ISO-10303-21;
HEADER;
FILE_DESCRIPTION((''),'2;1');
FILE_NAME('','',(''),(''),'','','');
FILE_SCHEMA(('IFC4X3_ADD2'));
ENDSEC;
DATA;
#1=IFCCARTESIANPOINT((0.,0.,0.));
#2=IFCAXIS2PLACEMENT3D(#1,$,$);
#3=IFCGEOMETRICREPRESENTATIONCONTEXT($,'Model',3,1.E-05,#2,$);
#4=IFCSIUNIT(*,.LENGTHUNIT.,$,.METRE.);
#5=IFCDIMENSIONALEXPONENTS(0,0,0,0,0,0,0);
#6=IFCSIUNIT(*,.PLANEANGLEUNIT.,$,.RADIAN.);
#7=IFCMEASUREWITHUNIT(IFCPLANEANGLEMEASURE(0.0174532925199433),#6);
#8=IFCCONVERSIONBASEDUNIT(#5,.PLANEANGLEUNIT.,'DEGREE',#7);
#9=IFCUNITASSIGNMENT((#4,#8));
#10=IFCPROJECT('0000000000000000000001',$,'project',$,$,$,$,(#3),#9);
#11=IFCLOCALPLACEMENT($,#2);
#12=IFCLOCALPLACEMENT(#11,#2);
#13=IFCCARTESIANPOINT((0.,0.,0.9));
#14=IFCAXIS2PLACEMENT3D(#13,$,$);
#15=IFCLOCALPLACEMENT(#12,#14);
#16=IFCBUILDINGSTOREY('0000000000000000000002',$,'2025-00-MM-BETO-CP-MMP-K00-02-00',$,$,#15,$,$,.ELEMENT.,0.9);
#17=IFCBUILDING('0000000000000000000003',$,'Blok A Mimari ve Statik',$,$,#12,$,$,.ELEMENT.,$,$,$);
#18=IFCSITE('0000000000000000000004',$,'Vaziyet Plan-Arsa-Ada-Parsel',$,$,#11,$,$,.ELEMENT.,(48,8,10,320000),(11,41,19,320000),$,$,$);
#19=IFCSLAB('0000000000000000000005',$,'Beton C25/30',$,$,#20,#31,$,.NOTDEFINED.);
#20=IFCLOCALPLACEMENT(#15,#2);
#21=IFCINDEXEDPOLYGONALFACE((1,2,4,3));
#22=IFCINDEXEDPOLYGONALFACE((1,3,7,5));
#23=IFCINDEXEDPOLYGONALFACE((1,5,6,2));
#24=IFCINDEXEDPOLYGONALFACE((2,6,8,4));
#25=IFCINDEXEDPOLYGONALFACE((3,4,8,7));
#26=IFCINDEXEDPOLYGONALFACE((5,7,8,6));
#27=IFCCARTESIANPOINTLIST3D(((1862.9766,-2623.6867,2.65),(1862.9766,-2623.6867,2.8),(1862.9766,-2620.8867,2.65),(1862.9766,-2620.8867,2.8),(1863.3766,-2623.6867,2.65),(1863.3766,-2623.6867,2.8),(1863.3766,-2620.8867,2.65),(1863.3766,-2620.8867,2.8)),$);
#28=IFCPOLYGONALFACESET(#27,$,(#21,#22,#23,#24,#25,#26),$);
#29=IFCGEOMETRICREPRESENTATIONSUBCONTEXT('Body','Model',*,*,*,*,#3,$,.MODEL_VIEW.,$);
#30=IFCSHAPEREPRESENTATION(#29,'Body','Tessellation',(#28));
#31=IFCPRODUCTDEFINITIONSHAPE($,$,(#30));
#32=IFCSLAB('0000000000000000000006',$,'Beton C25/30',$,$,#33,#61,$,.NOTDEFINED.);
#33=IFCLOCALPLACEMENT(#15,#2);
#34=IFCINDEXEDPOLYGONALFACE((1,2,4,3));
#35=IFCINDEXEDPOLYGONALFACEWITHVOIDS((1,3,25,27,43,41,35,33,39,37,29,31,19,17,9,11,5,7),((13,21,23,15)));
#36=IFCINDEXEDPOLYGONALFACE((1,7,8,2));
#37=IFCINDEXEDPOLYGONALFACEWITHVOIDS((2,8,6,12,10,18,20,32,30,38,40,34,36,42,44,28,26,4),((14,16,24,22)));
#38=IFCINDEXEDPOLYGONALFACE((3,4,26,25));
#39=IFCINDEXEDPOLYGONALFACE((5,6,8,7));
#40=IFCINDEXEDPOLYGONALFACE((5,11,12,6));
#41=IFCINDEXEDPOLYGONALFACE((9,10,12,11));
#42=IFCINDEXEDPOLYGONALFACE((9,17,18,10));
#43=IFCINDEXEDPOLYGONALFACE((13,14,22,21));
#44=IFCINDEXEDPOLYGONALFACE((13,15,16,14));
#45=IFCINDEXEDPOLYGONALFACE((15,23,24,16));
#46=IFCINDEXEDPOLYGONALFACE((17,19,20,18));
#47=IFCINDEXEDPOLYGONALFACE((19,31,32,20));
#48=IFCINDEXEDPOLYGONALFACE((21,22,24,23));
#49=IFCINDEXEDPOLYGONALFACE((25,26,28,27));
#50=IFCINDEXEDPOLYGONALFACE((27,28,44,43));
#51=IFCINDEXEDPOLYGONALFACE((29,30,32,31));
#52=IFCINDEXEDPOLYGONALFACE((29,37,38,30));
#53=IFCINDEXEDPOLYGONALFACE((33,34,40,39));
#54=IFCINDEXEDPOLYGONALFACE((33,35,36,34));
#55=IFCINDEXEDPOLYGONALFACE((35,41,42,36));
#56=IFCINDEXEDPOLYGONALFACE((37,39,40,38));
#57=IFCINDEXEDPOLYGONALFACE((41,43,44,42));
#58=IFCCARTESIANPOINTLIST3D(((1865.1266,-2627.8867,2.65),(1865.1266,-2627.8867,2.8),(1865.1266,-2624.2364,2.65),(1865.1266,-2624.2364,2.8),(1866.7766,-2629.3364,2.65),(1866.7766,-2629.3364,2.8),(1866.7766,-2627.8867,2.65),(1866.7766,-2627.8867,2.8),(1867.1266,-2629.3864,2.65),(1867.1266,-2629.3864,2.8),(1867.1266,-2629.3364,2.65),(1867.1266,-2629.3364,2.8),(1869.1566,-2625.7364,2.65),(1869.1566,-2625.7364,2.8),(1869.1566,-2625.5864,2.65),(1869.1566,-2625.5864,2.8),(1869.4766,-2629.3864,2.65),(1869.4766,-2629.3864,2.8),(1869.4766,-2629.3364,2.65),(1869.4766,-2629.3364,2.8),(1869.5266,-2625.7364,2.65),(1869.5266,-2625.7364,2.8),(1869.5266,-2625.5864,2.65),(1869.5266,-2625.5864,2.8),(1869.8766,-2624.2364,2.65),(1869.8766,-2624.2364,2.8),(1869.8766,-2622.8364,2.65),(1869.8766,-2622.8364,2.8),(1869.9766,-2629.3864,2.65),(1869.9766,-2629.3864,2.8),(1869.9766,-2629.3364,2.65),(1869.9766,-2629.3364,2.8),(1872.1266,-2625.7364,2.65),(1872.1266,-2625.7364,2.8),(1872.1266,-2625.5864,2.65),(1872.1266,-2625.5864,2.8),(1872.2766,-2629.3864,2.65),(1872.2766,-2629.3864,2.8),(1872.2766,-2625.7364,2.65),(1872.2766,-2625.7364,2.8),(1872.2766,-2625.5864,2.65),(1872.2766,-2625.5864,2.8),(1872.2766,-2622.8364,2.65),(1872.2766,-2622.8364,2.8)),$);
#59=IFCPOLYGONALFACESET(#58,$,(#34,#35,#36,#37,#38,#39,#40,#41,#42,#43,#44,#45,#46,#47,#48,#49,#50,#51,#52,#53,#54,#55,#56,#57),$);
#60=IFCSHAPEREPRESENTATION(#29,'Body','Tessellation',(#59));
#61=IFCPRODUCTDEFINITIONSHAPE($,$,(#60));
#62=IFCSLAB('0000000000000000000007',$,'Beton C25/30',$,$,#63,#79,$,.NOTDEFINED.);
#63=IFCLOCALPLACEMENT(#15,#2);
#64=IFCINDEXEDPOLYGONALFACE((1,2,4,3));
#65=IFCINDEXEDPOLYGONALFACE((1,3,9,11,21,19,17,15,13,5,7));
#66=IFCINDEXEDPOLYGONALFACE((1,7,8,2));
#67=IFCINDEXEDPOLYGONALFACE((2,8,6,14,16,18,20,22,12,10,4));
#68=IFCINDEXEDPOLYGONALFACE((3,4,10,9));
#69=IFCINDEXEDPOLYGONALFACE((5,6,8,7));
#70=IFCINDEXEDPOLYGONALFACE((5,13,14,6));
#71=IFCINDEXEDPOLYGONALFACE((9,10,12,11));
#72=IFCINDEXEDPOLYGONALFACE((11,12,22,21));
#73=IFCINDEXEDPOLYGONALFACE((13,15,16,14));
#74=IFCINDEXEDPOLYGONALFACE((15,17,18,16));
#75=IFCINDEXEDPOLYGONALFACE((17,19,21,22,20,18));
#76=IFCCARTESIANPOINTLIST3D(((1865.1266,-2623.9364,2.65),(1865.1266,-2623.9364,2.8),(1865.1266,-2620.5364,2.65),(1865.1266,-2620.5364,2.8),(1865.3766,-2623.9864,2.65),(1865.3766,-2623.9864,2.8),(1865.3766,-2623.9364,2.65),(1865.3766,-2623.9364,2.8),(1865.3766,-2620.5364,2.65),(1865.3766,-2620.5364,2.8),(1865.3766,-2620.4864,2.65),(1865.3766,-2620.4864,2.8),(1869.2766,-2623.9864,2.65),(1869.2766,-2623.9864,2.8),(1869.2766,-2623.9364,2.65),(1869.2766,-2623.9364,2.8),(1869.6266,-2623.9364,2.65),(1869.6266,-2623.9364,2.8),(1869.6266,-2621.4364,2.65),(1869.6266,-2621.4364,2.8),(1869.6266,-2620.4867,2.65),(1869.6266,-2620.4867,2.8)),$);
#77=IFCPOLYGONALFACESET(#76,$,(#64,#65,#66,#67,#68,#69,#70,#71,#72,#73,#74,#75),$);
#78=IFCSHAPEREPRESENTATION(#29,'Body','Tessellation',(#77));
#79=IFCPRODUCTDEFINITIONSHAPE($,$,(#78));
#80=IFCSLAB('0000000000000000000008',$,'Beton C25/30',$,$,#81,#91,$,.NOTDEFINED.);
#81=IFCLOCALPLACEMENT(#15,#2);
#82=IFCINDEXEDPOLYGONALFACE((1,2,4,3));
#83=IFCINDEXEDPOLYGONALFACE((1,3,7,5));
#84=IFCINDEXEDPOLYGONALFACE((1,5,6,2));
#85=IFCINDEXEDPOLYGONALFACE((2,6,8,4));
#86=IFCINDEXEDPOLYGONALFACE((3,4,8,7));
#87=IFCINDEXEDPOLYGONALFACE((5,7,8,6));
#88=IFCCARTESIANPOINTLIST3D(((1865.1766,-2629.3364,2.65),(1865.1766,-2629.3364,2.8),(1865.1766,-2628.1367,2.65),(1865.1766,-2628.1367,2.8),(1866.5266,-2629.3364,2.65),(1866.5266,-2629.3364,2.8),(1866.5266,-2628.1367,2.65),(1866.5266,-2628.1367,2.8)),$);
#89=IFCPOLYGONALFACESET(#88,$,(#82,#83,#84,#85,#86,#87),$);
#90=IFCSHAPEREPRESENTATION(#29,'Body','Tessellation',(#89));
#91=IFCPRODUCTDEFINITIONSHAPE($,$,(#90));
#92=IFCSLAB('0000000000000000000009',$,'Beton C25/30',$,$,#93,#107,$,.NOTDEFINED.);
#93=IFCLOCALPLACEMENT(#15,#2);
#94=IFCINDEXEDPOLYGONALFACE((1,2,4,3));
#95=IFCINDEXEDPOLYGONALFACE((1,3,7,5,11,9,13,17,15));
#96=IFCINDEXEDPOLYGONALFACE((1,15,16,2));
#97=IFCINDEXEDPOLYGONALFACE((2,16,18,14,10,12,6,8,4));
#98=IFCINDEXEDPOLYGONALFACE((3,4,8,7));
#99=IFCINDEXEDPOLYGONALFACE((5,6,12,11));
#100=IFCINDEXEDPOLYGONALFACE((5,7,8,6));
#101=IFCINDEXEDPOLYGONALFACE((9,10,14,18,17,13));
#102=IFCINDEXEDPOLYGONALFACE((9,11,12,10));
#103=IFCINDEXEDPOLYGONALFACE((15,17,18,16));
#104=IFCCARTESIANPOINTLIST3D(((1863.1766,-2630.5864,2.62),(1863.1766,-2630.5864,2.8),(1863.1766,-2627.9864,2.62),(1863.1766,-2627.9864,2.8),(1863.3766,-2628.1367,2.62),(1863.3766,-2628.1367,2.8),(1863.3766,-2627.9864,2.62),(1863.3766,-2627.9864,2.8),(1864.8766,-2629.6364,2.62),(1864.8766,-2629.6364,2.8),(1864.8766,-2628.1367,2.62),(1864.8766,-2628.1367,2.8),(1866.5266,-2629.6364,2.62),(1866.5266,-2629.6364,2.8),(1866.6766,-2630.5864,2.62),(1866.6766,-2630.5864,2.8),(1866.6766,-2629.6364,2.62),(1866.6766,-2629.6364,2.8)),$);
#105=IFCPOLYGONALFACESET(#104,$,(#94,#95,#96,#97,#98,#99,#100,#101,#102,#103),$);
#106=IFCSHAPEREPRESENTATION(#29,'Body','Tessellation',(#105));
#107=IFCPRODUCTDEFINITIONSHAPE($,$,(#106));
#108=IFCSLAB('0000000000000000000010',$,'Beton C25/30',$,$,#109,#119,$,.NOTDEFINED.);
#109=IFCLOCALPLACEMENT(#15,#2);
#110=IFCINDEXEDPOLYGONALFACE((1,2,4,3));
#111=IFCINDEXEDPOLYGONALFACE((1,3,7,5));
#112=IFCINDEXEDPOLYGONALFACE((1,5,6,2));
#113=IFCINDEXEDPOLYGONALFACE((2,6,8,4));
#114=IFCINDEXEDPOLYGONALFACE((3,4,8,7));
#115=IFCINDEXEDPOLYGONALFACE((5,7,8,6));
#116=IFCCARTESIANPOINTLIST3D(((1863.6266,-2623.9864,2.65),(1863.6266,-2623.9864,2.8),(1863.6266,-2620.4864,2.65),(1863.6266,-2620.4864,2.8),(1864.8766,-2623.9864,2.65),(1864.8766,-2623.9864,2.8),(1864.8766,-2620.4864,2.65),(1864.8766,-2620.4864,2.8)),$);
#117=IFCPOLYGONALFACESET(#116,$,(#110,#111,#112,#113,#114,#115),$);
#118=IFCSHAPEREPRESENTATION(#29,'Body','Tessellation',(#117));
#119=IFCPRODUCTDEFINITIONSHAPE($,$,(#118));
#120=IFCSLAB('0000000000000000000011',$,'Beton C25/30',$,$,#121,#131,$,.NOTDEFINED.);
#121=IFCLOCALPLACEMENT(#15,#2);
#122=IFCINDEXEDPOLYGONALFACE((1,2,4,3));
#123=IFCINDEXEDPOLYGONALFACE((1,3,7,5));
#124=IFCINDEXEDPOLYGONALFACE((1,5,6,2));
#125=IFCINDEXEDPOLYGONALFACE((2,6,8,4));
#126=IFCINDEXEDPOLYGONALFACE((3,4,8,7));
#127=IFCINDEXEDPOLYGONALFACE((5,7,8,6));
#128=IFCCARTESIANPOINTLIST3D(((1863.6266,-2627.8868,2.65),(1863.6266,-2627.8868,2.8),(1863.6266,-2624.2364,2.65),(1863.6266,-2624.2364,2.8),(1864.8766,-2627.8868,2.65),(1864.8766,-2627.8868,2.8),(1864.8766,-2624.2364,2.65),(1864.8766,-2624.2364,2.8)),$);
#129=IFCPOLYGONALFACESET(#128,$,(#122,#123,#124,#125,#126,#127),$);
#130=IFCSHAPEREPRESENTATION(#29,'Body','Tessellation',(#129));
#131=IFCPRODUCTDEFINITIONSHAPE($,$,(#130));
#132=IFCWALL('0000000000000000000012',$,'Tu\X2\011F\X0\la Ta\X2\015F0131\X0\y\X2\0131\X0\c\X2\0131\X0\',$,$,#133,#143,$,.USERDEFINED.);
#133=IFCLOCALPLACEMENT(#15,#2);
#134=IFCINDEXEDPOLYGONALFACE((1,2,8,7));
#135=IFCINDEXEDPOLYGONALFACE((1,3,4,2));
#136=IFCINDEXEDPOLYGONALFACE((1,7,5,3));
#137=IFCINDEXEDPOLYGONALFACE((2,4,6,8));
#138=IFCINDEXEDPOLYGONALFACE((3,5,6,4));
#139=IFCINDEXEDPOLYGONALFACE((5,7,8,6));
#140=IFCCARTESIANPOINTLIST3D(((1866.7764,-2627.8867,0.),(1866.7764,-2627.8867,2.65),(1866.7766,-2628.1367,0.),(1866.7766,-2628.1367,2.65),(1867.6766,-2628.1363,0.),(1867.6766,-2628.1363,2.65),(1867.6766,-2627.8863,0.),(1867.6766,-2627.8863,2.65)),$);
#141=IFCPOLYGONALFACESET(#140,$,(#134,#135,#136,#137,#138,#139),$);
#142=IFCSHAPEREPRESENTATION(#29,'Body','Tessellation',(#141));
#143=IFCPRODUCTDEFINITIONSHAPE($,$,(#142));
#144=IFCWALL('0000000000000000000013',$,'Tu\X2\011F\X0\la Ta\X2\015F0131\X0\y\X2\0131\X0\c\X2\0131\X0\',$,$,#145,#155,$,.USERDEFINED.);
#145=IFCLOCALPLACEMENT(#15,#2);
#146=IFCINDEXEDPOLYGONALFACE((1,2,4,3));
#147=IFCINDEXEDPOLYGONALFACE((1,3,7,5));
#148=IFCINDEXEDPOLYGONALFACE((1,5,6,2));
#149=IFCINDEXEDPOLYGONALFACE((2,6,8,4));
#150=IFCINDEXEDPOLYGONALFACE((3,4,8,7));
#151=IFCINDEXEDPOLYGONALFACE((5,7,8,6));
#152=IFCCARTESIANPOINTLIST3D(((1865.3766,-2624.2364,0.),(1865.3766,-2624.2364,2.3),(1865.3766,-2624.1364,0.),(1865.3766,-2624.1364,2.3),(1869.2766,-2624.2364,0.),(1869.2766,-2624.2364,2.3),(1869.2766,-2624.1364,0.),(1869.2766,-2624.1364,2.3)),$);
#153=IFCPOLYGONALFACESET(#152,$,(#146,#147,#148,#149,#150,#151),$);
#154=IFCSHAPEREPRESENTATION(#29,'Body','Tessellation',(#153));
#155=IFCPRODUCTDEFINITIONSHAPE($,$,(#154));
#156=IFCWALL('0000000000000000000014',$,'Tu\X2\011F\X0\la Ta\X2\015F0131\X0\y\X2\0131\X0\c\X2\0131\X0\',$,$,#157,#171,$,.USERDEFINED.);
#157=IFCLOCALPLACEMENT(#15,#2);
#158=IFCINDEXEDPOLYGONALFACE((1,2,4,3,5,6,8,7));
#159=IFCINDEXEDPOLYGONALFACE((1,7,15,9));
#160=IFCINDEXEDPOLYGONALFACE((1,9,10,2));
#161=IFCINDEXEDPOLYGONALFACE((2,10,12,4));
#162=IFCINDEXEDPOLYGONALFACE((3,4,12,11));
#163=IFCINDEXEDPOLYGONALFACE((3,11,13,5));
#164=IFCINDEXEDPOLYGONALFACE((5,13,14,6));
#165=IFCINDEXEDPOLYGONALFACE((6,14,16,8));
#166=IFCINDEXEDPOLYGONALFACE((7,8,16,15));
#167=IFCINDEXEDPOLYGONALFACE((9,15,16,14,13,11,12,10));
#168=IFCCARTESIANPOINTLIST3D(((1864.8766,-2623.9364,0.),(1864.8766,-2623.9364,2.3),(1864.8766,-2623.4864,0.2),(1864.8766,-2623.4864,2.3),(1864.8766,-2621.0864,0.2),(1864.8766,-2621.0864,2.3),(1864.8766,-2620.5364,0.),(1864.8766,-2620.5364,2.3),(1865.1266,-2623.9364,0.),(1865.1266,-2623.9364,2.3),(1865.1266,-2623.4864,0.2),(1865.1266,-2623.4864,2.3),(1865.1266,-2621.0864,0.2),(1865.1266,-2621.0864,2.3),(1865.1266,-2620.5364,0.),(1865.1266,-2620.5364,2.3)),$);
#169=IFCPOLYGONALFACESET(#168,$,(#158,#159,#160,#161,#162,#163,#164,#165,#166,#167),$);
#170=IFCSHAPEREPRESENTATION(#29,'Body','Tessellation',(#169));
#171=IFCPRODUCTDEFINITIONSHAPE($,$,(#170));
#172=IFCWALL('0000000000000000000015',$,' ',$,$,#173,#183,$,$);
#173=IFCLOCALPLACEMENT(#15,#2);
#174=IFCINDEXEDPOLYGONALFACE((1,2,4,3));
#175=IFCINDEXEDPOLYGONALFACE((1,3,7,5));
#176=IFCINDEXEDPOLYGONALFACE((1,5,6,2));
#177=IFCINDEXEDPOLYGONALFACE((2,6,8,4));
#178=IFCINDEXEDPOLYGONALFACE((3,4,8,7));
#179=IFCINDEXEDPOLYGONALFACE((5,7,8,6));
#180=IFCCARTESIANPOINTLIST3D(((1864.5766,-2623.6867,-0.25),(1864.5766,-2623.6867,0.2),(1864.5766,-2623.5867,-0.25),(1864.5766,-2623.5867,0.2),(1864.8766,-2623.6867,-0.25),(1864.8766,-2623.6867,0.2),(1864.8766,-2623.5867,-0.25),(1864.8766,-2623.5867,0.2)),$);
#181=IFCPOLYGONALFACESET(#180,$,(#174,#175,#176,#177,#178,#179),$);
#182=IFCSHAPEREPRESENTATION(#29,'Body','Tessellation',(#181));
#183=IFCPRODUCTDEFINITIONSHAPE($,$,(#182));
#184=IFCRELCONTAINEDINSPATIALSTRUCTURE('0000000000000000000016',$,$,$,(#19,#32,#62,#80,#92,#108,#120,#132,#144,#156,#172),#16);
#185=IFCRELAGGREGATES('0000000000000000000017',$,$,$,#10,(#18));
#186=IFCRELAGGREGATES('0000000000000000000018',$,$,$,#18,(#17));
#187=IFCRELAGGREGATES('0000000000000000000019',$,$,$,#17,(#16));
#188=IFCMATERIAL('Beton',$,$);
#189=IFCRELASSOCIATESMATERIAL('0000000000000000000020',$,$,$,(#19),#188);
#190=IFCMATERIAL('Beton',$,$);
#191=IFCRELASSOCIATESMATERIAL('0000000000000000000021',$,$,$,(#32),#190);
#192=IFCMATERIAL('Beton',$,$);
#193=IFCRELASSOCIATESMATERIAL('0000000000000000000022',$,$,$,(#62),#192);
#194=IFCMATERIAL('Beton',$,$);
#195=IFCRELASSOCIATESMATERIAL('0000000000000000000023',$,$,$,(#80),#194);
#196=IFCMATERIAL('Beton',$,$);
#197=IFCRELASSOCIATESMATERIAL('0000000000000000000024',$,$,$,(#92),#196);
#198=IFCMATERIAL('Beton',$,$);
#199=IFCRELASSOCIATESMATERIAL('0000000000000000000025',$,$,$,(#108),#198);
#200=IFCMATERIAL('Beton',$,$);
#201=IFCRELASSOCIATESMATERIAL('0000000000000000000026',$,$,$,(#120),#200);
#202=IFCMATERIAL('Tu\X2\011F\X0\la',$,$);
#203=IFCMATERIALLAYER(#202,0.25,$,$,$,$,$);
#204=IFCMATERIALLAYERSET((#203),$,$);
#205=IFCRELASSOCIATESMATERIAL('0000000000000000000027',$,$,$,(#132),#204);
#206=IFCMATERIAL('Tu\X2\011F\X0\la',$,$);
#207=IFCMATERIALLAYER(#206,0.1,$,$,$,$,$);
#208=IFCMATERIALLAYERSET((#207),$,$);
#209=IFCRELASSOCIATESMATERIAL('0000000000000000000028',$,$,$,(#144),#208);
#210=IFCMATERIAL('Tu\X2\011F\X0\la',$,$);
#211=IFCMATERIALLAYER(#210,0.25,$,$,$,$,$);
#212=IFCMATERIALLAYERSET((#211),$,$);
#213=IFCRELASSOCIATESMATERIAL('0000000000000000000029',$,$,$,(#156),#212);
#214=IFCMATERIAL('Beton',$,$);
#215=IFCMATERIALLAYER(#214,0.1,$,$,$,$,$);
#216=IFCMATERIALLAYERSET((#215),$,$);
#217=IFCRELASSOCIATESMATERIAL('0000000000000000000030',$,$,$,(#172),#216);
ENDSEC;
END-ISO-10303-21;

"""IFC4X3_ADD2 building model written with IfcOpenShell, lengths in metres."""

from ifc_helpers import new_model, entity, si_unit, converted_unit, frame, frame_2d, origin, origin_with_axes, place, context, subcontext, project, spatial, polyline, rectangle, outline, extrude, material, layer, layer_set, layer_usage, element, save


model = new_model("IFC4X3_ADD2")

# Units and contexts
model_context = context("Model", 3, precision=1e-05, world=origin())
body_context = subcontext(model_context, "Body", "Model", "MODEL_VIEW")
ifc_project = project(units=[si_unit("LENGTHUNIT", "METRE"), converted_unit("PLANEANGLEUNIT", "DEGREE", entity("IfcPlaneAngleMeasure", 0.0174532925199433), si_unit("PLANEANGLEUNIT", "RADIAN"), dimensions=[0, 0, 0, 0, 0, 0, 0])], contexts=[model_context])

# Site, building, storey
site_placement = place(None, origin())
site = spatial("IfcSite", under=ifc_project, at=site_placement, Name="Vaziyet Plan-Arsa-Ada-Parsel", CompositionType="ELEMENT", RefLatitude=(48, 8, 10, 320000), RefLongitude=(11, 41, 19, 320000))
building_placement = place(site_placement, origin())
building = spatial("IfcBuilding", under=site, at=building_placement, Name="Blok A Mimari ve Statik", CompositionType="ELEMENT")
storey_placement = place(building_placement, frame((0.0, 0.0, 0.9)))
storey = spatial("IfcBuildingStorey", under=building, at=storey_placement, Name="2025-00-MM-BETO-CP-MMP-K00-02-00", CompositionType="ELEMENT", Elevation=0.9)

# Slab
ifc_material_1 = material(Name="Beton")
slab_1_placement = place(storey_placement, frame((1862.9766, -2623.6867, 2.65)))
element("IfcSlab", 1, at=slab_1_placement, inside=storey, material=ifc_material_1, Name="Beton C25/30", PredefinedType="NOTDEFINED", context=body_context, shape_type="SweptSolid", body=[
    extrude(rectangle(XDim=2.8, YDim=0.4, at=frame_2d((0.2, -1.4), x_axis=(0.0, -1.0))), frame((0.0, 2.8, 0.0), z_axis=(0.0, 0.0, 1.0), x_axis=(1.0, 0.0, 0.0)), (0.0, 0.0, 1.0), 0.15),
])

# Slab, opening
ifc_material_2 = material(Name="Beton")
slab_2_placement = place(storey_placement, frame((1865.1266, -2629.3864, 2.65)))
slab_2 = element("IfcSlab", 2, at=slab_2_placement, inside=storey, material=ifc_material_2, Name="Beton C25/30", PredefinedType="NOTDEFINED", context=body_context, shape_type="SweptSolid", body=[
    extrude(outline(polyline([(4.75, 6.55), (4.75, 5.15), (0.0, 5.15), (0.0, 1.4997), (1.65, 1.4997), (1.65, 1.2497), (1.65, 0.05), (2.0, 0.05), (2.0, 0.0), (4.35, 0.0), (4.35, 0.05), (4.85, 0.05), (4.85, 0.0), (7.15, 0.0), (7.15, 6.55), (4.75, 6.55)]), holes=[polyline([(4.4, 3.8), (4.4, 3.65), (4.03, 3.65), (4.03, 3.8), (4.4, 3.8)])]), origin_with_axes(), (0.0, 0.0, 1.0), 0.15),
])
opening_1_placement = place(slab_2_placement, frame((7.0, 3.65, 0.0)))
element("IfcOpeningElement", 3, at=opening_1_placement, cuts=slab_2, PredefinedType="OPENING", context=body_context, shape_type="SweptSolid", body=[
    extrude(rectangle(XDim=0.15, YDim=0.15, at=frame_2d((0.0, 0.0), x_axis=(0.0, -1.0))), frame((0.075, 0.075, 0.0), z_axis=(0.0, 0.0, 1.0), x_axis=(1.0, 0.0, 0.0)), (0.0, 0.0, 1.0), 0.15),
])

# Slabs
ifc_material_3 = material(Name="Beton")
slab_3_placement = place(storey_placement, frame((1865.1266, -2623.9864, 2.65)))
element("IfcSlab", 4, at=slab_3_placement, inside=storey, material=ifc_material_3, Name="Beton C25/30", PredefinedType="NOTDEFINED", context=body_context, shape_type="SweptSolid", body=[
    extrude(outline(polyline([(0.25, 3.5), (0.25, 3.45), (0.0, 3.45), (0.0, 0.05), (0.25, 0.05), (0.25, 0.0), (4.15, 0.0), (4.15, 0.05), (4.5, 0.05), (4.5, 2.55), (4.5, 3.4997), (0.25, 3.5)])), origin_with_axes(), (0.0, 0.0, 1.0), 0.15),
])
ifc_material_4 = material(Name="Beton")
slab_4_placement = place(storey_placement, frame((1865.1766, -2629.3364, 2.65)))
element("IfcSlab", 5, at=slab_4_placement, inside=storey, material=ifc_material_4, Name="Beton C25/30", PredefinedType="NOTDEFINED", context=body_context, shape_type="SweptSolid", body=[
    extrude(rectangle(XDim=1.35, YDim=1.1997, at=frame_2d((0.675, 0.5998), x_axis=(1.0, 0.0))), origin_with_axes(), (0.0, 0.0, 1.0), 0.15),
])
ifc_material_5 = material(Name="Beton")
slab_5_placement = place(storey_placement, frame((1863.1766, -2630.5864, 2.62)))
element("IfcSlab", 6, at=slab_5_placement, inside=storey, material=ifc_material_5, Name="Beton C25/30", PredefinedType="NOTDEFINED", context=body_context, shape_type="SweptSolid", body=[
    extrude(outline(polyline([(1.7, 0.95), (1.7, 2.4497), (0.2, 2.4497), (0.2, 2.6), (0.0, 2.6), (0.0, 0.0), (3.5, 0.0), (3.5, 0.95), (3.35, 0.95), (1.7, 0.95)])), origin_with_axes(), (0.0, 0.0, 1.0), 0.18),
])
ifc_material_6 = material(Name="Beton")
slab_6_placement = place(storey_placement, frame((1863.6266, -2623.9864, 2.65)))
element("IfcSlab", 7, at=slab_6_placement, inside=storey, material=ifc_material_6, Name="Beton C25/30", PredefinedType="NOTDEFINED", context=body_context, shape_type="SweptSolid", body=[
    extrude(rectangle(XDim=3.5, YDim=1.25, at=frame_2d((0.625, -1.75), x_axis=(0.0, -1.0))), frame((0.0, 3.5, 0.0), z_axis=(0.0, 0.0, 1.0), x_axis=(1.0, 0.0, 0.0)), (0.0, 0.0, 1.0), 0.15),
])
ifc_material_7 = material(Name="Beton")
slab_7_placement = place(storey_placement, frame((1863.6266, -2627.8868, 2.65)))
element("IfcSlab", 8, at=slab_7_placement, inside=storey, material=ifc_material_7, Name="Beton C25/30", PredefinedType="NOTDEFINED", context=body_context, shape_type="SweptSolid", body=[
    extrude(outline(polyline([(0.0, 0.0), (1.25, 0.0), (1.25, 3.6503), (0.0, 3.6503), (0.0, 0.0)])), origin_with_axes(), (0.0, 0.0, 1.0), 0.15),
])

# Walls
ifc_material_8 = material(Name="Tuğla")
ifc_layer_1 = layer(ifc_material_8, 0.25)
ifc_layer_set_1 = layer_set([ifc_layer_1])
ifc_layer_usage_1 = layer_usage(ifc_layer_set_1, "AXIS2", "POSITIVE", 0.0)
wall_1_placement = place(storey_placement, frame((1866.7766, -2628.1367, 0.0), z_axis=(0.0, 0.0, 1.0), x_axis=(1.0, 0.000476, 0.0)))
element("IfcWall", 9, at=wall_1_placement, inside=storey, material=ifc_layer_usage_1, Name="Tuğla Taşıyıcı", PredefinedType="USERDEFINED", context=body_context, shape_type="SweptSolid", body=[
    extrude(outline(polyline([(0.0001, 0.0), (0.9001, 0.0), (0.9002, 0.25), (0.0001, 0.25), (0.0001, 0.0)])), frame((-0.0001, 0.0, 0.0), z_axis=(0.0, 0.0, 1.0), x_axis=(1.0, 0.0, 0.0)), (0.0, 0.0, 1.0), 2.65),
])
ifc_material_9 = material(Name="Tuğla")
ifc_layer_2 = layer(ifc_material_9, 0.1)
ifc_layer_set_2 = layer_set([ifc_layer_2])
ifc_layer_usage_2 = layer_usage(ifc_layer_set_2, "AXIS2", "POSITIVE", 0.0)
wall_2_placement = place(storey_placement, frame((1865.3766, -2624.2364, 0.0), z_axis=(0.0, 0.0, 1.0), x_axis=(1.0, 0.0, 0.0)))
element("IfcWall", 10, at=wall_2_placement, inside=storey, material=ifc_layer_usage_2, Name="Tuğla Taşıyıcı", PredefinedType="USERDEFINED", context=body_context, shape_type="SweptSolid", body=[
    extrude(rectangle(XDim=3.9, YDim=0.1, at=frame_2d((1.95, 0.05), x_axis=(1.0, 0.0))), origin_with_axes(), (0.0, 0.0, 1.0), 2.3),
])

# Wall, opening
ifc_material_10 = material(Name="Tuğla")
ifc_layer_3 = layer(ifc_material_10, 0.25)
ifc_layer_set_3 = layer_set([ifc_layer_3])
ifc_layer_usage_3 = layer_usage(ifc_layer_set_3, "AXIS2", "POSITIVE", 0.0)
wall_3_placement = place(storey_placement, frame((1864.8766, -2620.5364, 0.0), z_axis=(0.0, 0.0, 1.0), x_axis=(0.0, -1.0, 0.0)))
wall_3 = element("IfcWall", 11, at=wall_3_placement, inside=storey, material=ifc_layer_usage_3, Name="Tuğla Taşıyıcı", PredefinedType="USERDEFINED", context=body_context, shape_type="SweptSolid", body=[
    extrude(rectangle(XDim=3.4, YDim=0.25, at=frame_2d((1.7, 0.125), x_axis=(1.0, 0.0))), origin_with_axes(), (0.0, 0.0, 1.0), 2.3),
])
opening_2_placement = place(wall_3_placement, frame((0.55, 0.0, 0.2), z_axis=(0.0, 1.0, 0.0), x_axis=(0.0, 0.0, 1.0)))
element("IfcOpeningElement", 12, at=opening_2_placement, cuts=wall_3, PredefinedType="OPENING", context=body_context, shape_type="SweptSolid", body=[
    extrude(outline(polyline([(2.1, 2.4), (2.1, 0.0), (0.0, 0.0), (0.0, 2.4), (2.1, 2.4)])), origin_with_axes(), (0.0, 0.0, 1.0), 0.25),
])

# Wall
ifc_material_11 = material(Name="Beton")
ifc_layer_4 = layer(ifc_material_11, 0.1)
ifc_layer_set_4 = layer_set([ifc_layer_4])
ifc_layer_usage_4 = layer_usage(ifc_layer_set_4, "AXIS2", "POSITIVE", 0.0)
wall_4_placement = place(storey_placement, frame((1864.5766, -2623.6867, -0.25)))
element("IfcWall", 13, at=wall_4_placement, inside=storey, material=ifc_layer_usage_4, Name=" ", context=body_context, shape_type="SweptSolid", body=[
    extrude(rectangle(XDim=0.3, YDim=0.1, at=frame_2d((0.15, 0.05), x_axis=(1.0, 0.0))), origin_with_axes(), (0.0, 0.0, 1.0), 0.45),
])

save(model, "model.ifc")
